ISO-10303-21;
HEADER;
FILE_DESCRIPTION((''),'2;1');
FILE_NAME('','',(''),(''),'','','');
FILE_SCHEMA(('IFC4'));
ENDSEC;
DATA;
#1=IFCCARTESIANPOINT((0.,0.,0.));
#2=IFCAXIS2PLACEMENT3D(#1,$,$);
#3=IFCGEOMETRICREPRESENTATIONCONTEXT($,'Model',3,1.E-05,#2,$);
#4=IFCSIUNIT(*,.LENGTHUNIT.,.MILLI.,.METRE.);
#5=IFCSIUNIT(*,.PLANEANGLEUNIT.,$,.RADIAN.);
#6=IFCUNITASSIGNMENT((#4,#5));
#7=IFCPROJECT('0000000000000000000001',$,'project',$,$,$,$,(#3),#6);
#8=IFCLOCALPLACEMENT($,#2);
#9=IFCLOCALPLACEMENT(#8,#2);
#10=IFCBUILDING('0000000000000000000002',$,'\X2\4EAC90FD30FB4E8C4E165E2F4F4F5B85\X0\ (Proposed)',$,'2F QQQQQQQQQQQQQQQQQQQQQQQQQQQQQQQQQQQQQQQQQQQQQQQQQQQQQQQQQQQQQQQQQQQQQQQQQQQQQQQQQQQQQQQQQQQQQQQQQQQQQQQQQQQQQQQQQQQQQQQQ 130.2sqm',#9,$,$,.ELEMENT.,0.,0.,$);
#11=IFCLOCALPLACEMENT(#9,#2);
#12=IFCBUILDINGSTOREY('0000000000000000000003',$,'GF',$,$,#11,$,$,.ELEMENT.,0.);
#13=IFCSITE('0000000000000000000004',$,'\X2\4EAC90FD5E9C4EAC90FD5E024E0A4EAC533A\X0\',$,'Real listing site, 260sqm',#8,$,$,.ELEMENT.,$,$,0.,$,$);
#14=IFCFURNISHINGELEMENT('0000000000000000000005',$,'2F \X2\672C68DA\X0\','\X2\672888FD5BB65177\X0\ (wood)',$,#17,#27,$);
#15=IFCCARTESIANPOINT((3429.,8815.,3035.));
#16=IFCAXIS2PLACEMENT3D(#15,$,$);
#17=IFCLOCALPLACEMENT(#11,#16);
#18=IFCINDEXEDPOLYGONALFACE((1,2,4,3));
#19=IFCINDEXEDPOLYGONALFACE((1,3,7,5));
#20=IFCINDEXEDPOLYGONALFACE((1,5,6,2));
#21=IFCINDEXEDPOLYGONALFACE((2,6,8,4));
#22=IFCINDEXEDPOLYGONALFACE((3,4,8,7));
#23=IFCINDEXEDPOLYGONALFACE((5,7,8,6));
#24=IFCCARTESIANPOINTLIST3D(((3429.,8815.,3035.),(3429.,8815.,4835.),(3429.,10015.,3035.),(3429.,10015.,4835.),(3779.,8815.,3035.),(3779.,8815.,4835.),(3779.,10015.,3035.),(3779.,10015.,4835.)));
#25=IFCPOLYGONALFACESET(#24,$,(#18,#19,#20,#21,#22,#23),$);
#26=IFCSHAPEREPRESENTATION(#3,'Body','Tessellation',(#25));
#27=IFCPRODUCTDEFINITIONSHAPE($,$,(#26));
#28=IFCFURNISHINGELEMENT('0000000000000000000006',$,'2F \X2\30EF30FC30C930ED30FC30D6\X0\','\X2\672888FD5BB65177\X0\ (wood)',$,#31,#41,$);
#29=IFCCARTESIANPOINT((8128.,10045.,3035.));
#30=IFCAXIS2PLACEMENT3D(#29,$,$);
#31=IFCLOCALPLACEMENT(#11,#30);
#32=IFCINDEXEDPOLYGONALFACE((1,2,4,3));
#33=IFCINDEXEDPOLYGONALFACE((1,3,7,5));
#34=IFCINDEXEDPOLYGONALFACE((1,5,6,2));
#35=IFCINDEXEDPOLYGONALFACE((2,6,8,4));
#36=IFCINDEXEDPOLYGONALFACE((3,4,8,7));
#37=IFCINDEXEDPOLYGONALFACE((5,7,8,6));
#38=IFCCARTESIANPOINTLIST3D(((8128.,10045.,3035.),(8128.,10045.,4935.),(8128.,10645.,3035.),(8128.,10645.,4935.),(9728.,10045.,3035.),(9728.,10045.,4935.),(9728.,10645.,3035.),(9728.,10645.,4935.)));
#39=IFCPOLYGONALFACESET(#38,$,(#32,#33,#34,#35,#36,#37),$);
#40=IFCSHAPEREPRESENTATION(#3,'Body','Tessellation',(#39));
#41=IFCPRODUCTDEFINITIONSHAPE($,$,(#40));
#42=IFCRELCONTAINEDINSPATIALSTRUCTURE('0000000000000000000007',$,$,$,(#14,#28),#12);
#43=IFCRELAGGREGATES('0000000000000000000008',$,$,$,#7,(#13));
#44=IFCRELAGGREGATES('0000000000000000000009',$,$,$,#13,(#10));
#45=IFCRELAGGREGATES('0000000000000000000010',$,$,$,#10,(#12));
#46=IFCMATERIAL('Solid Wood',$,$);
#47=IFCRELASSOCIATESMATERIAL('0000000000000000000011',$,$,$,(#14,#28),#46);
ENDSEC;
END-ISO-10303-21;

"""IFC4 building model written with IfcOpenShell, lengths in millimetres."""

from ifc_helpers import new_model, si_unit, frame, frame_2d, origin, place, context, project, spatial, rectangle, extrude, material, element, save


model = new_model("IFC4")

# Units and contexts
model_context = context("Model", 3, precision=1e-05, world=origin())
ifc_project = project(units=[si_unit("LENGTHUNIT", "METRE", prefix="MILLI"), si_unit("PLANEANGLEUNIT", "RADIAN")], contexts=[model_context])

# Site, building, storey
site_placement = place(None, origin())
site = spatial("IfcSite", under=ifc_project, at=site_placement, Name="京都府京都市上京区", ObjectType="Real listing site, 260sqm", CompositionType="ELEMENT", RefElevation=0.0)
building_placement = place(site_placement, origin())
building = spatial("IfcBuilding", under=site, at=building_placement, Name="京都・二世帯住宅 (Proposed)", ObjectType="2F QQQQQQQQQQQQQQQQQQQQQQQQQQQQQQQQQQQQQQQQQQQQQQQQQQQQQQQQQQQQQQQQQQQQQQQQQQQQQQQQQQQQQQQQQQQQQQQQQQQQQQQQQQQQQQQQQQQQQQQQ 130.2sqm", CompositionType="ELEMENT", ElevationOfRefHeight=0.0, ElevationOfTerrain=0.0)
storey_placement = place(building_placement, origin())
storey = spatial("IfcBuildingStorey", under=building, at=storey_placement, Name="GF", CompositionType="ELEMENT", Elevation=0.0)

# Shared definitions
ifc_material_1 = material(Name="Solid Wood")

# Furnishing elements
furnishing_1_placement = place(storey_placement, frame((3429.0, 8815.0, 3035.0)))
element("IfcFurnishingElement", 1, at=furnishing_1_placement, inside=storey, material=ifc_material_1, Name="2F 本棚", Description="木製家具 (wood)", context=model_context, shape_type="SweptSolid", body=[
    extrude(rectangle(XDim=350.0, YDim=1200.0, at=frame_2d((175.0, 600.0))), frame((3429.0, 8815.0, 3035.0)), (0.0, 0.0, 1.0), 1800.0),
])
furnishing_2_placement = place(storey_placement, frame((8128.0, 10045.0, 3035.0)))
element("IfcFurnishingElement", 2, at=furnishing_2_placement, inside=storey, material=ifc_material_1, Name="2F ワードローブ", Description="木製家具 (wood)", context=model_context, shape_type="SweptSolid", body=[
    extrude(rectangle(XDim=1600.0, YDim=600.0, at=frame_2d((800.0, 300.0))), frame((8128.0, 10045.0, 3035.0)), (0.0, 0.0, 1.0), 1900.0),
])

save(model, "model.ifc")
